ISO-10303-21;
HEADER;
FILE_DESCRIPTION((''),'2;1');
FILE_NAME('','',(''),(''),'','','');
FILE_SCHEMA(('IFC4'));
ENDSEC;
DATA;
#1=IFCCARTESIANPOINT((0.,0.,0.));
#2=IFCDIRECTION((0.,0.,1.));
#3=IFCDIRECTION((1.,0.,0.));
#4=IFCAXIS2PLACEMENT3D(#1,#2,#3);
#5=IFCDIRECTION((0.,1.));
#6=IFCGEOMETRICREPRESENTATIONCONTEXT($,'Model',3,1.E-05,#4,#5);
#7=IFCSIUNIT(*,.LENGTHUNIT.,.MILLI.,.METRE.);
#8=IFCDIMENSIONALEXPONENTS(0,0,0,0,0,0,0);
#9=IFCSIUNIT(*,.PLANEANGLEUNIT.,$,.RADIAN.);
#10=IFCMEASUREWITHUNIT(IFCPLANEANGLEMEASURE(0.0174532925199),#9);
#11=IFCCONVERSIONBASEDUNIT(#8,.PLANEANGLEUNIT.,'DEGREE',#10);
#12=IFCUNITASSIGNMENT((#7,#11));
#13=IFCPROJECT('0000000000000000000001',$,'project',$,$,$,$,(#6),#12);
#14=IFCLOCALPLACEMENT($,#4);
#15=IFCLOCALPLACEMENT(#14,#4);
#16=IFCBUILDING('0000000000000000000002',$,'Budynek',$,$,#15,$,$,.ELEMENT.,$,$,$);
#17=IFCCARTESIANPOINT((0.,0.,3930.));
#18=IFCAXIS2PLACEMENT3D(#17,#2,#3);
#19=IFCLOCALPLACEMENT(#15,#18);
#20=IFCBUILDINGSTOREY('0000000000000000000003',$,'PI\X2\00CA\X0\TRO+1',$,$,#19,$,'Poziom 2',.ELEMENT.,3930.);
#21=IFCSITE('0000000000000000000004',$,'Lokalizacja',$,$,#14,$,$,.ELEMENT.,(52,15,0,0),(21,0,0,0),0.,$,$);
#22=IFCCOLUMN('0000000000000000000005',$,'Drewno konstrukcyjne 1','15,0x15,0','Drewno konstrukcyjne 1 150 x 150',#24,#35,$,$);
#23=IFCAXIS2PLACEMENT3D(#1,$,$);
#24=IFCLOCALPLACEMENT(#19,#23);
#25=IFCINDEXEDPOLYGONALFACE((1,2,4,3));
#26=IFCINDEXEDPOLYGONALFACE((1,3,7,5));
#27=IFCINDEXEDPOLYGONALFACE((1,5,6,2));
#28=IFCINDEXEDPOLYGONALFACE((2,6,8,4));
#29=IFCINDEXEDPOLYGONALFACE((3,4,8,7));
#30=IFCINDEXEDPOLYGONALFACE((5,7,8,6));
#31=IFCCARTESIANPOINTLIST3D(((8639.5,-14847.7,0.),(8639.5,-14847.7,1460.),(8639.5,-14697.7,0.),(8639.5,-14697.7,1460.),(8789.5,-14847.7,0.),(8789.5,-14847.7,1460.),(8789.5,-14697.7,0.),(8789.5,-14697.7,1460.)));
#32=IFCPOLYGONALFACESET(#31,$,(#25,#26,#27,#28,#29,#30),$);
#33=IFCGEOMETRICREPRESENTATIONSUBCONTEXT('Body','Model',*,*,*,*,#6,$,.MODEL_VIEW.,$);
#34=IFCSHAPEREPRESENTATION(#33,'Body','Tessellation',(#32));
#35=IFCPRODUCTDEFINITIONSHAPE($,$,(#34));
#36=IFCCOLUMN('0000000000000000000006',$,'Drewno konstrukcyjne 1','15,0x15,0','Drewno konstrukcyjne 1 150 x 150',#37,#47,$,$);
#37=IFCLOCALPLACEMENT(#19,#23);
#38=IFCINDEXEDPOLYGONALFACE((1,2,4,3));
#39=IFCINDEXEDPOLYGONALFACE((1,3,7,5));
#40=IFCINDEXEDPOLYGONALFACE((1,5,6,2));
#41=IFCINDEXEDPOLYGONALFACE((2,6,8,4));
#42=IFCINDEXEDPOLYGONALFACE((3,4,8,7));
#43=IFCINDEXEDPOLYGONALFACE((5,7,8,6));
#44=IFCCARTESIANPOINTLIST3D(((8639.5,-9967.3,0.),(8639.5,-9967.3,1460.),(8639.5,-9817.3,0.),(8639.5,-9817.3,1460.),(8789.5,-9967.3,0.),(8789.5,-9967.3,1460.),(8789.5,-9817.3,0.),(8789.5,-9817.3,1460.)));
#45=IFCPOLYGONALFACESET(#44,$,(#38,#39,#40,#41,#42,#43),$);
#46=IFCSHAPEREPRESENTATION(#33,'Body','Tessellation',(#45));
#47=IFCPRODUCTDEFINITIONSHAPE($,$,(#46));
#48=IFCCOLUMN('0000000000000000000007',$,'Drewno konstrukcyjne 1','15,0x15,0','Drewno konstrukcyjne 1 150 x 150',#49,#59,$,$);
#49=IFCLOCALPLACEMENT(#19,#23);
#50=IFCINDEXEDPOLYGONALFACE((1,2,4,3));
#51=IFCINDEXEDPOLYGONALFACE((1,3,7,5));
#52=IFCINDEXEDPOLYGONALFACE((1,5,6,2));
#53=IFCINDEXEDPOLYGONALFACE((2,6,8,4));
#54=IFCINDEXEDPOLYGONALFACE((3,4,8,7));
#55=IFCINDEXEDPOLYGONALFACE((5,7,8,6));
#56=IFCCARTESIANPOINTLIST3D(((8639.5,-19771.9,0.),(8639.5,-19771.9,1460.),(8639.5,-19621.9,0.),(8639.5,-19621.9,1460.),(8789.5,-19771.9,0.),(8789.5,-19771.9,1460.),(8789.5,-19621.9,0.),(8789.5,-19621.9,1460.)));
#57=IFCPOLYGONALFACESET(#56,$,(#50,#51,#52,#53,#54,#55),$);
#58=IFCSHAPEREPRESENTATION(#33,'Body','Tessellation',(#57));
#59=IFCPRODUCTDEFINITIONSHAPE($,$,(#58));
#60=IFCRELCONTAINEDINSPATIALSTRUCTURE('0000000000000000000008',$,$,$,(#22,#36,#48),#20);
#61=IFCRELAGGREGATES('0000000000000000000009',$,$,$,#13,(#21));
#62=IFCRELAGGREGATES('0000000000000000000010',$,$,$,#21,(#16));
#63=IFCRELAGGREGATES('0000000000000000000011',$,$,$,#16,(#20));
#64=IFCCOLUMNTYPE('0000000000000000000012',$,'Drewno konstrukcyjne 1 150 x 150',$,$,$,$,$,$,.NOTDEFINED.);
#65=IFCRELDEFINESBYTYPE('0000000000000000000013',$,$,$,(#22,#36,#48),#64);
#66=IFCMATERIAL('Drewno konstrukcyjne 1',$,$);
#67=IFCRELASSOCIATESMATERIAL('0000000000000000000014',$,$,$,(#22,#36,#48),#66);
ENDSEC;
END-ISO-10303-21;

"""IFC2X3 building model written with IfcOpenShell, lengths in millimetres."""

from ifc_helpers import new_model, entity, si_unit, converted_unit, direction, frame, origin_with_axes, origin_2d_with_axis, place, context, subcontext, project, spatial, rectangle, extrude, material, type_object, element, save


model = new_model("IFC2X3")

# Units and contexts
model_context = context("Model", 3, precision=1e-05, world=origin_with_axes(), true_north=direction((0.0, 1.0)))
body_context = subcontext(model_context, "Body", "Model", "MODEL_VIEW")
ifc_project = project(units=[si_unit("LENGTHUNIT", "METRE", prefix="MILLI"), converted_unit("PLANEANGLEUNIT", "DEGREE", entity("IfcPlaneAngleMeasure", 0.0174532925199), si_unit("PLANEANGLEUNIT", "RADIAN"), dimensions=[0, 0, 0, 0, 0, 0, 0])], contexts=[model_context])

# Site, building, storey
site_placement = place(None, origin_with_axes())
site = spatial("IfcSite", under=ifc_project, at=site_placement, Name="Lokalizacja", CompositionType="ELEMENT", RefLatitude=(52, 15, 0, 0), RefLongitude=(21, 0, 0, 0), RefElevation=0.0)
building_placement = place(site_placement, origin_with_axes())
building = spatial("IfcBuilding", under=site, at=building_placement, Name="Budynek", CompositionType="ELEMENT")
storey_placement = place(building_placement, frame((0.0, 0.0, 3930.0), z_axis=(0.0, 0.0, 1.0), x_axis=(1.0, 0.0, 0.0)))
storey = spatial("IfcBuildingStorey", under=building, at=storey_placement, Name="PIÊTRO+1", LongName="Poziom 2", CompositionType="ELEMENT", Elevation=3930.0)

# Columns
ifc_material_1 = material(Name="Drewno konstrukcyjne 1")
column_type = type_object("IfcColumnType", Name="Drewno konstrukcyjne 1 150 x 150", PredefinedType="NOTDEFINED")
for number, where, z_axis, x_axis, name in (
    (1, (8714.5, -14772.7, 0.0), (0.0, 0.0, 1.0), (1.0, 0.0, 0.0), "Drewno konstrukcyjne 1"),
    (2, (8714.5, -9892.3, 0.0), (0.0, 0.0, 1.0), (1.0, 0.0, 0.0), "Drewno konstrukcyjne 1"),
    (3, (8714.5, -19696.9, 0.0), (0.0, 0.0, 1.0), (1.0, 0.0, 0.0), "Drewno konstrukcyjne 1"),
):
    element("IfcColumn", number, at=place(storey_placement, frame(where, z_axis=z_axis, x_axis=x_axis)), inside=storey, type_object=column_type, material=ifc_material_1, Name=name, Description="15,0x15,0", ObjectType="Drewno konstrukcyjne 1 150 x 150", context=body_context, shape_type="SweptSolid", body=[
        extrude(rectangle(XDim=150.0, YDim=150.0, at=origin_2d_with_axis()), origin_with_axes(), (0.0, 0.0, 1.0), 1460.0),
    ])

save(model, "model.ifc")
